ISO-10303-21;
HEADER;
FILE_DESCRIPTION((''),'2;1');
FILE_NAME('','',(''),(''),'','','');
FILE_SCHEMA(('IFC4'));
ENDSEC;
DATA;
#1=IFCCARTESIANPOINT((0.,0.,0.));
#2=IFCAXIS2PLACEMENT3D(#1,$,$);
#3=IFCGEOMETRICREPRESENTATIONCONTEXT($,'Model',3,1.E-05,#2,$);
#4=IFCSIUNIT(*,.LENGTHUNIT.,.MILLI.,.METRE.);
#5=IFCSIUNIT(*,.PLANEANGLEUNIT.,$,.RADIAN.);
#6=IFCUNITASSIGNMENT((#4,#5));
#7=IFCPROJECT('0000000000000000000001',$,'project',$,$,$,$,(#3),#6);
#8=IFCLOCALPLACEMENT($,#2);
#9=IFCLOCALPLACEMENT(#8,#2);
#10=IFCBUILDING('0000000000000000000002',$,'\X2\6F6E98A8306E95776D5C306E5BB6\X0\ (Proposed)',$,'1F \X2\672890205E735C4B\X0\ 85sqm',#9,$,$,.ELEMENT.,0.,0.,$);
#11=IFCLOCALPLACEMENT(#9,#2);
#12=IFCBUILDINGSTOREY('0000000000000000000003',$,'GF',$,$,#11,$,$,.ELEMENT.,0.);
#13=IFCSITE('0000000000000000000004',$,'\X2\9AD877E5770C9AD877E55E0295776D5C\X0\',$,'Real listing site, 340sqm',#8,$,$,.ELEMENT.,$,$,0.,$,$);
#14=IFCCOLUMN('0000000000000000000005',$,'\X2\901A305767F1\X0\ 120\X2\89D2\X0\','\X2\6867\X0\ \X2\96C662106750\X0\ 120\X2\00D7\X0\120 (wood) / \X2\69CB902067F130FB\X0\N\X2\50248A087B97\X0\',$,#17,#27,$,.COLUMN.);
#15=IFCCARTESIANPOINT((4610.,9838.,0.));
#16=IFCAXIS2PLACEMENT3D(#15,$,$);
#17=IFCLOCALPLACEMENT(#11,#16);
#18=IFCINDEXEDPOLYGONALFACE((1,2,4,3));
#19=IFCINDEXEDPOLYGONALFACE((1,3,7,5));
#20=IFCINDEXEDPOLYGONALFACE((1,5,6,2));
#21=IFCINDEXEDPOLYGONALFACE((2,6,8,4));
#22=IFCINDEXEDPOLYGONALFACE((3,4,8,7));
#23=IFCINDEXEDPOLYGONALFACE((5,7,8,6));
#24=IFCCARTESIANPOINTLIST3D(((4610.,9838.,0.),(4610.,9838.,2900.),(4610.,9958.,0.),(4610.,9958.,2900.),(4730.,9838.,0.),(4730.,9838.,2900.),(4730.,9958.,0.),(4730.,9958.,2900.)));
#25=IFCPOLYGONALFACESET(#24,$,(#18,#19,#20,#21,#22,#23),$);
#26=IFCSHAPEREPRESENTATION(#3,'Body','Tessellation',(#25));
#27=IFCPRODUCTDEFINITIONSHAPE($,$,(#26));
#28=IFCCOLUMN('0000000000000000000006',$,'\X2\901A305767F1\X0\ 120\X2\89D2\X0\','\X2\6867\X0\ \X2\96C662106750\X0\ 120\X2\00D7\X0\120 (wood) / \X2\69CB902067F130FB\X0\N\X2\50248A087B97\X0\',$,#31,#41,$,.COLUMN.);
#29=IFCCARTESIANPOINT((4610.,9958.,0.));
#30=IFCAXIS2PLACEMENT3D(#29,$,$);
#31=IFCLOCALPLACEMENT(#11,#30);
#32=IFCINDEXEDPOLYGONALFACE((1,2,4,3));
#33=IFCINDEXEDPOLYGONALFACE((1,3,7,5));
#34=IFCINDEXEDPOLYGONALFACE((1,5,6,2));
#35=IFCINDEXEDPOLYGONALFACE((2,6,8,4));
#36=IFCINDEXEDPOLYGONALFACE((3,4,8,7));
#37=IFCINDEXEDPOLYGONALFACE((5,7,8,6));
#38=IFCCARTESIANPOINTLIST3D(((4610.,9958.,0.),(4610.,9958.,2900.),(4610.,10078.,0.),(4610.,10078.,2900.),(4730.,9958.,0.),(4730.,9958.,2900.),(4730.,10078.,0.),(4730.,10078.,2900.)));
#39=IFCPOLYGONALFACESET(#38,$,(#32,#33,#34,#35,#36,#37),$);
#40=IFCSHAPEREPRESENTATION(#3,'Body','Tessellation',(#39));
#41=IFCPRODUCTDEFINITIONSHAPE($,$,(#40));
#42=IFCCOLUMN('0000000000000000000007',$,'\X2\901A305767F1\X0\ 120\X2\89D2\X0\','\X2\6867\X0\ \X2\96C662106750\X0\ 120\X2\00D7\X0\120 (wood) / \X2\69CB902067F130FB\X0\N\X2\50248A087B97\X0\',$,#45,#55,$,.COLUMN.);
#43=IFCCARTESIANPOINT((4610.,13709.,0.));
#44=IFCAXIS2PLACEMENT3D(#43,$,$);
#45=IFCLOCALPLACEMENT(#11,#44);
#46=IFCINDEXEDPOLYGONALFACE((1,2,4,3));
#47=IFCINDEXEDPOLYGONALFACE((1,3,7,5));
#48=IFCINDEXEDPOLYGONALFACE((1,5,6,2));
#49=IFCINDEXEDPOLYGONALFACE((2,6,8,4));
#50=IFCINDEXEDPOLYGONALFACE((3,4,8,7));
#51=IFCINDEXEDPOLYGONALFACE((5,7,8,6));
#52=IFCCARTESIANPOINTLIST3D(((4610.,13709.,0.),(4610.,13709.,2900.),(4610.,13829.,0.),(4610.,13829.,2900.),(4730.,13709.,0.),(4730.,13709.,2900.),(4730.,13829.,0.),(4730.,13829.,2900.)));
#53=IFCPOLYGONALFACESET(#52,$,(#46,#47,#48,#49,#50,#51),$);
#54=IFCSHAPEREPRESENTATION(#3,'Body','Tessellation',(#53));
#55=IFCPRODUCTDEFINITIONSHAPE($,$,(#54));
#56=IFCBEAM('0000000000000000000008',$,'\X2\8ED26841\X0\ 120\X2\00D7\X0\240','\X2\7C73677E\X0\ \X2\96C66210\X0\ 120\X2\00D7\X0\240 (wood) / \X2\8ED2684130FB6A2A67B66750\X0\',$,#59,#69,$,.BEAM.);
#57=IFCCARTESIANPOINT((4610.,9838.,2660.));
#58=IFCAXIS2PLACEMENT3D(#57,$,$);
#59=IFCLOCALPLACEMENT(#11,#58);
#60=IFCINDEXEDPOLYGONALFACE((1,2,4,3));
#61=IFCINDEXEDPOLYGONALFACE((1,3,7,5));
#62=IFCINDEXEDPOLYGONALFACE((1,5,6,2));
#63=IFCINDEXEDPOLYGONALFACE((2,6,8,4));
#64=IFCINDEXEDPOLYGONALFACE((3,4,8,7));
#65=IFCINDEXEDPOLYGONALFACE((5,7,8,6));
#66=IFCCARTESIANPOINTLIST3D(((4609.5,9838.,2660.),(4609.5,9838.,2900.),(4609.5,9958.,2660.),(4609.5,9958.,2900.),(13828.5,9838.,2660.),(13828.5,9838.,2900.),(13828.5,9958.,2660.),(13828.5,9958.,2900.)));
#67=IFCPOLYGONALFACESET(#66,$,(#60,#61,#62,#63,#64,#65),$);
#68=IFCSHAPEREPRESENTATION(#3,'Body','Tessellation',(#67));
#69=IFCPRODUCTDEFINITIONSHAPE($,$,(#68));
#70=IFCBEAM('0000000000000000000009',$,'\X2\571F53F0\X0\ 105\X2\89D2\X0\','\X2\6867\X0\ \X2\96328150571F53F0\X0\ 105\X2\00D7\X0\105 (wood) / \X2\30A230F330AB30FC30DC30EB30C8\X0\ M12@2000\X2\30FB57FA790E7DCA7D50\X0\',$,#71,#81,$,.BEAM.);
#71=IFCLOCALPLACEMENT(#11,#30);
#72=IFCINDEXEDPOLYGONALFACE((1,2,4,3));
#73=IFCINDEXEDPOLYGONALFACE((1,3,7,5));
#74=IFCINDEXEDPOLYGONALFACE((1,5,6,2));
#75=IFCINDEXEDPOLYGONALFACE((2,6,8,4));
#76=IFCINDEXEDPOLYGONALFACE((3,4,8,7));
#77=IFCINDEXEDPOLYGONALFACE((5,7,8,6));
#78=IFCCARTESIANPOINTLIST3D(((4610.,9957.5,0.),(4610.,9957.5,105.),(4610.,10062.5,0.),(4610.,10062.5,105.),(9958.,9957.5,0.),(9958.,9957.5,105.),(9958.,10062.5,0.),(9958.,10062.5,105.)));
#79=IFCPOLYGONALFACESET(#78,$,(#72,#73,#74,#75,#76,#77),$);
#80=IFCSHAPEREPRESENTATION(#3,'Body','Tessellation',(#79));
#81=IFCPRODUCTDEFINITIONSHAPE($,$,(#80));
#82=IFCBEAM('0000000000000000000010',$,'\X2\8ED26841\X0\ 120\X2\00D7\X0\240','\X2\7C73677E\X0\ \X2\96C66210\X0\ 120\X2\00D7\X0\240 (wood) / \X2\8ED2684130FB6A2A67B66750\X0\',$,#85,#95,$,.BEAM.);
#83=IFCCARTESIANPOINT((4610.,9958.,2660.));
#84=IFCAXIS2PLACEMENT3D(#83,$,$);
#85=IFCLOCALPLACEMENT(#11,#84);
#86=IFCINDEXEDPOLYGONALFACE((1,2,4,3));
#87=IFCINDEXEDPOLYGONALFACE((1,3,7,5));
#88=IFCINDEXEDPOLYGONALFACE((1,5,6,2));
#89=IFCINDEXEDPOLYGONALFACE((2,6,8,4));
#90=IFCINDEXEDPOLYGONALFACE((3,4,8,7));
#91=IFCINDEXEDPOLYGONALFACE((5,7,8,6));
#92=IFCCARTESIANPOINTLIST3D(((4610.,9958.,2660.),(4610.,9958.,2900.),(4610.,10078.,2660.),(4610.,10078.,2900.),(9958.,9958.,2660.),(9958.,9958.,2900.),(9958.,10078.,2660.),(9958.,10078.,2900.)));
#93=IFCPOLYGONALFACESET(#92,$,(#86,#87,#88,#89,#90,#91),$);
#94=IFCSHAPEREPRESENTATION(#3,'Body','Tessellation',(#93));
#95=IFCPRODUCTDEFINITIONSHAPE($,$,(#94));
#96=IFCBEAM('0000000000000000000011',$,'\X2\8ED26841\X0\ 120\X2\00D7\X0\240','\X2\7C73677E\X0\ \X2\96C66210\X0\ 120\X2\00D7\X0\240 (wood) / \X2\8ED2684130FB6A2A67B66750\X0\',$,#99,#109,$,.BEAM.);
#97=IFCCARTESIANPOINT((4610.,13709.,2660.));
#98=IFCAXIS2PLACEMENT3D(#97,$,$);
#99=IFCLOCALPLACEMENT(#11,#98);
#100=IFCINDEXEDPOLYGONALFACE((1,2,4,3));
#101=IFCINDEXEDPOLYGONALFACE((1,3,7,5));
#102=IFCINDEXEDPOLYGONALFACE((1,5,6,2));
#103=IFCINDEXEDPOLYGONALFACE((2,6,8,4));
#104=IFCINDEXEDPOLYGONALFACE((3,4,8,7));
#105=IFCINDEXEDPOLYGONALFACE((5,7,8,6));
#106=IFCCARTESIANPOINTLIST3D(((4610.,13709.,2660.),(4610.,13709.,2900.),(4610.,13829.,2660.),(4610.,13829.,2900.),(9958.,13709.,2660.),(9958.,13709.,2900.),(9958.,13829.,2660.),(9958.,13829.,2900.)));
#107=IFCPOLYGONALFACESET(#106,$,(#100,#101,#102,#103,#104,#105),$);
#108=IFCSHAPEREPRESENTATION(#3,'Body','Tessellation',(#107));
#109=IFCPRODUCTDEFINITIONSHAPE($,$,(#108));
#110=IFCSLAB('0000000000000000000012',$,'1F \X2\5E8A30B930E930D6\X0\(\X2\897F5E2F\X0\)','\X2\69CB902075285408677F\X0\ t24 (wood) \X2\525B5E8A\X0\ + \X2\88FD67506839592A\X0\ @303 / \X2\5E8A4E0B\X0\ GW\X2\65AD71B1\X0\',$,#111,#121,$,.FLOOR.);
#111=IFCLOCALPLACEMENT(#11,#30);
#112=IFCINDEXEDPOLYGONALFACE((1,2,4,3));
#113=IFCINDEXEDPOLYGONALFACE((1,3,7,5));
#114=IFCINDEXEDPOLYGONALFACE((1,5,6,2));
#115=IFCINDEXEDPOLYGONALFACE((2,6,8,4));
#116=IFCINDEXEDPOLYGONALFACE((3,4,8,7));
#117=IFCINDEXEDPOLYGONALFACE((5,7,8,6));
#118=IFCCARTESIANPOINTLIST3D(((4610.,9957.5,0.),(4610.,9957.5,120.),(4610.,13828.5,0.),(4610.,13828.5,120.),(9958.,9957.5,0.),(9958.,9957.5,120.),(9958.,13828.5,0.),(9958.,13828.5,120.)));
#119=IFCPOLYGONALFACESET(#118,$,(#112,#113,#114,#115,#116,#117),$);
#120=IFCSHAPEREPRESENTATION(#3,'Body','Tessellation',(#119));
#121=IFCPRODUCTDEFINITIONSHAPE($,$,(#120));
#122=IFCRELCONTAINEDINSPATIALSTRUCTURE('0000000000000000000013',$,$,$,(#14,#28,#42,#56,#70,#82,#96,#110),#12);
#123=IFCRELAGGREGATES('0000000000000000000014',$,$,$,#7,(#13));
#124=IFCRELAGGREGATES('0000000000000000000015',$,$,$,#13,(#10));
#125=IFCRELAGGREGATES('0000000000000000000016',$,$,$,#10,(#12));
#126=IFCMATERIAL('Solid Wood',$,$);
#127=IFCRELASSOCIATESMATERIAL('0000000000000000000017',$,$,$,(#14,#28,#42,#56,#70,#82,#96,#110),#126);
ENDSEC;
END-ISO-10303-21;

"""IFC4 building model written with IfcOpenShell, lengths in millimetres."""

from ifc_helpers import new_model, si_unit, frame, frame_2d, origin, place, context, project, spatial, rectangle, extrude, material, element, save


model = new_model("IFC4")

# Units and contexts
model_context = context("Model", 3, precision=1e-05, world=origin())
ifc_project = project(units=[si_unit("LENGTHUNIT", "METRE", prefix="MILLI"), si_unit("PLANEANGLEUNIT", "RADIAN")], contexts=[model_context])

# Site, building, storey
site_placement = place(None, origin())
site = spatial("IfcSite", under=ifc_project, at=site_placement, Name="高知県高知市長浜", ObjectType="Real listing site, 340sqm", CompositionType="ELEMENT", RefElevation=0.0)
building_placement = place(site_placement, origin())
building = spatial("IfcBuilding", under=site, at=building_placement, Name="潮風の長浜の家 (Proposed)", ObjectType="1F 木造平屋 85sqm", CompositionType="ELEMENT", ElevationOfRefHeight=0.0, ElevationOfTerrain=0.0)
storey_placement = place(building_placement, origin())
storey = spatial("IfcBuildingStorey", under=building, at=storey_placement, Name="GF", CompositionType="ELEMENT", Elevation=0.0)

# Columns
ifc_material_1 = material(Name="Solid Wood")
column_1_placement = place(storey_placement, frame((4610.0, 9838.0, 0.0)))
element("IfcColumn", 1, at=column_1_placement, inside=storey, material=ifc_material_1, Name="通し柱 120角", Description="桧 集成材 120×120 (wood) / 構造柱・N値計算", PredefinedType="COLUMN", context=model_context, shape_type="SweptSolid", body=[
    extrude(rectangle(XDim=120.0, YDim=120.0, at=frame_2d((60.0, 60.0))), frame((4610.0, 9838.0, 0.0)), (0.0, 0.0, 1.0), 2900.0),
])
column_2_placement = place(storey_placement, frame((4610.0, 9958.0, 0.0)))
element("IfcColumn", 2, at=column_2_placement, inside=storey, material=ifc_material_1, Name="通し柱 120角", Description="桧 集成材 120×120 (wood) / 構造柱・N値計算", PredefinedType="COLUMN", context=model_context, shape_type="SweptSolid", body=[
    extrude(rectangle(XDim=120.0, YDim=120.0, at=frame_2d((60.0, 60.0))), frame((4610.0, 9958.0, 0.0)), (0.0, 0.0, 1.0), 2900.0),
])
column_3_placement = place(storey_placement, frame((4610.0, 13709.0, 0.0)))
element("IfcColumn", 3, at=column_3_placement, inside=storey, material=ifc_material_1, Name="通し柱 120角", Description="桧 集成材 120×120 (wood) / 構造柱・N値計算", PredefinedType="COLUMN", context=model_context, shape_type="SweptSolid", body=[
    extrude(rectangle(XDim=120.0, YDim=120.0, at=frame_2d((60.0, 60.0))), frame((4610.0, 13709.0, 0.0)), (0.0, 0.0, 1.0), 2900.0),
])

# Beams
beam_1_placement = place(storey_placement, frame((4610.0, 9838.0, 2660.0)))
element("IfcBeam", 4, at=beam_1_placement, inside=storey, material=ifc_material_1, Name="軒桁 120×240", Description="米松 集成 120×240 (wood) / 軒桁・横架材", PredefinedType="BEAM", context=model_context, shape_type="SweptSolid", body=[
    extrude(rectangle(XDim=9219.0, YDim=120.0, at=frame_2d((4609.0, 60.0))), frame((4610.0, 9838.0, 2660.0)), (0.0, 0.0, 1.0), 240.0),
])
beam_2_placement = place(storey_placement, frame((4610.0, 9958.0, 0.0)))
element("IfcBeam", 5, at=beam_2_placement, inside=storey, material=ifc_material_1, Name="土台 105角", Description="桧 防腐土台 105×105 (wood) / アンカーボルト M12@2000・基礎緊結", PredefinedType="BEAM", context=model_context, shape_type="SweptSolid", body=[
    extrude(rectangle(XDim=5348.0, YDim=105.0, at=frame_2d((2674.0, 52.0))), frame((4610.0, 9958.0, 0.0)), (0.0, 0.0, 1.0), 105.0),
])
beam_3_placement = place(storey_placement, frame((4610.0, 9958.0, 2660.0)))
element("IfcBeam", 6, at=beam_3_placement, inside=storey, material=ifc_material_1, Name="軒桁 120×240", Description="米松 集成 120×240 (wood) / 軒桁・横架材", PredefinedType="BEAM", context=model_context, shape_type="SweptSolid", body=[
    extrude(rectangle(XDim=5348.0, YDim=120.0, at=frame_2d((2674.0, 60.0))), frame((4610.0, 9958.0, 2660.0)), (0.0, 0.0, 1.0), 240.0),
])
beam_4_placement = place(storey_placement, frame((4610.0, 13709.0, 2660.0)))
element("IfcBeam", 7, at=beam_4_placement, inside=storey, material=ifc_material_1, Name="軒桁 120×240", Description="米松 集成 120×240 (wood) / 軒桁・横架材", PredefinedType="BEAM", context=model_context, shape_type="SweptSolid", body=[
    extrude(rectangle(XDim=5348.0, YDim=120.0, at=frame_2d((2674.0, 60.0))), frame((4610.0, 13709.0, 2660.0)), (0.0, 0.0, 1.0), 240.0),
])

# Slab
slab_placement = place(storey_placement, frame((4610.0, 9958.0, 0.0)))
element("IfcSlab", 8, at=slab_placement, inside=storey, material=ifc_material_1, Name="1F 床スラブ(西帯)", Description="構造用合板 t24 (wood) 剛床 + 製材根太 @303 / 床下 GW断熱", PredefinedType="FLOOR", context=model_context, shape_type="SweptSolid", body=[
    extrude(rectangle(XDim=5348.0, YDim=3871.0, at=frame_2d((2674.0, 1935.0))), frame((4610.0, 9958.0, 0.0)), (0.0, 0.0, 1.0), 120.0),
])

save(model, "model.ifc")
